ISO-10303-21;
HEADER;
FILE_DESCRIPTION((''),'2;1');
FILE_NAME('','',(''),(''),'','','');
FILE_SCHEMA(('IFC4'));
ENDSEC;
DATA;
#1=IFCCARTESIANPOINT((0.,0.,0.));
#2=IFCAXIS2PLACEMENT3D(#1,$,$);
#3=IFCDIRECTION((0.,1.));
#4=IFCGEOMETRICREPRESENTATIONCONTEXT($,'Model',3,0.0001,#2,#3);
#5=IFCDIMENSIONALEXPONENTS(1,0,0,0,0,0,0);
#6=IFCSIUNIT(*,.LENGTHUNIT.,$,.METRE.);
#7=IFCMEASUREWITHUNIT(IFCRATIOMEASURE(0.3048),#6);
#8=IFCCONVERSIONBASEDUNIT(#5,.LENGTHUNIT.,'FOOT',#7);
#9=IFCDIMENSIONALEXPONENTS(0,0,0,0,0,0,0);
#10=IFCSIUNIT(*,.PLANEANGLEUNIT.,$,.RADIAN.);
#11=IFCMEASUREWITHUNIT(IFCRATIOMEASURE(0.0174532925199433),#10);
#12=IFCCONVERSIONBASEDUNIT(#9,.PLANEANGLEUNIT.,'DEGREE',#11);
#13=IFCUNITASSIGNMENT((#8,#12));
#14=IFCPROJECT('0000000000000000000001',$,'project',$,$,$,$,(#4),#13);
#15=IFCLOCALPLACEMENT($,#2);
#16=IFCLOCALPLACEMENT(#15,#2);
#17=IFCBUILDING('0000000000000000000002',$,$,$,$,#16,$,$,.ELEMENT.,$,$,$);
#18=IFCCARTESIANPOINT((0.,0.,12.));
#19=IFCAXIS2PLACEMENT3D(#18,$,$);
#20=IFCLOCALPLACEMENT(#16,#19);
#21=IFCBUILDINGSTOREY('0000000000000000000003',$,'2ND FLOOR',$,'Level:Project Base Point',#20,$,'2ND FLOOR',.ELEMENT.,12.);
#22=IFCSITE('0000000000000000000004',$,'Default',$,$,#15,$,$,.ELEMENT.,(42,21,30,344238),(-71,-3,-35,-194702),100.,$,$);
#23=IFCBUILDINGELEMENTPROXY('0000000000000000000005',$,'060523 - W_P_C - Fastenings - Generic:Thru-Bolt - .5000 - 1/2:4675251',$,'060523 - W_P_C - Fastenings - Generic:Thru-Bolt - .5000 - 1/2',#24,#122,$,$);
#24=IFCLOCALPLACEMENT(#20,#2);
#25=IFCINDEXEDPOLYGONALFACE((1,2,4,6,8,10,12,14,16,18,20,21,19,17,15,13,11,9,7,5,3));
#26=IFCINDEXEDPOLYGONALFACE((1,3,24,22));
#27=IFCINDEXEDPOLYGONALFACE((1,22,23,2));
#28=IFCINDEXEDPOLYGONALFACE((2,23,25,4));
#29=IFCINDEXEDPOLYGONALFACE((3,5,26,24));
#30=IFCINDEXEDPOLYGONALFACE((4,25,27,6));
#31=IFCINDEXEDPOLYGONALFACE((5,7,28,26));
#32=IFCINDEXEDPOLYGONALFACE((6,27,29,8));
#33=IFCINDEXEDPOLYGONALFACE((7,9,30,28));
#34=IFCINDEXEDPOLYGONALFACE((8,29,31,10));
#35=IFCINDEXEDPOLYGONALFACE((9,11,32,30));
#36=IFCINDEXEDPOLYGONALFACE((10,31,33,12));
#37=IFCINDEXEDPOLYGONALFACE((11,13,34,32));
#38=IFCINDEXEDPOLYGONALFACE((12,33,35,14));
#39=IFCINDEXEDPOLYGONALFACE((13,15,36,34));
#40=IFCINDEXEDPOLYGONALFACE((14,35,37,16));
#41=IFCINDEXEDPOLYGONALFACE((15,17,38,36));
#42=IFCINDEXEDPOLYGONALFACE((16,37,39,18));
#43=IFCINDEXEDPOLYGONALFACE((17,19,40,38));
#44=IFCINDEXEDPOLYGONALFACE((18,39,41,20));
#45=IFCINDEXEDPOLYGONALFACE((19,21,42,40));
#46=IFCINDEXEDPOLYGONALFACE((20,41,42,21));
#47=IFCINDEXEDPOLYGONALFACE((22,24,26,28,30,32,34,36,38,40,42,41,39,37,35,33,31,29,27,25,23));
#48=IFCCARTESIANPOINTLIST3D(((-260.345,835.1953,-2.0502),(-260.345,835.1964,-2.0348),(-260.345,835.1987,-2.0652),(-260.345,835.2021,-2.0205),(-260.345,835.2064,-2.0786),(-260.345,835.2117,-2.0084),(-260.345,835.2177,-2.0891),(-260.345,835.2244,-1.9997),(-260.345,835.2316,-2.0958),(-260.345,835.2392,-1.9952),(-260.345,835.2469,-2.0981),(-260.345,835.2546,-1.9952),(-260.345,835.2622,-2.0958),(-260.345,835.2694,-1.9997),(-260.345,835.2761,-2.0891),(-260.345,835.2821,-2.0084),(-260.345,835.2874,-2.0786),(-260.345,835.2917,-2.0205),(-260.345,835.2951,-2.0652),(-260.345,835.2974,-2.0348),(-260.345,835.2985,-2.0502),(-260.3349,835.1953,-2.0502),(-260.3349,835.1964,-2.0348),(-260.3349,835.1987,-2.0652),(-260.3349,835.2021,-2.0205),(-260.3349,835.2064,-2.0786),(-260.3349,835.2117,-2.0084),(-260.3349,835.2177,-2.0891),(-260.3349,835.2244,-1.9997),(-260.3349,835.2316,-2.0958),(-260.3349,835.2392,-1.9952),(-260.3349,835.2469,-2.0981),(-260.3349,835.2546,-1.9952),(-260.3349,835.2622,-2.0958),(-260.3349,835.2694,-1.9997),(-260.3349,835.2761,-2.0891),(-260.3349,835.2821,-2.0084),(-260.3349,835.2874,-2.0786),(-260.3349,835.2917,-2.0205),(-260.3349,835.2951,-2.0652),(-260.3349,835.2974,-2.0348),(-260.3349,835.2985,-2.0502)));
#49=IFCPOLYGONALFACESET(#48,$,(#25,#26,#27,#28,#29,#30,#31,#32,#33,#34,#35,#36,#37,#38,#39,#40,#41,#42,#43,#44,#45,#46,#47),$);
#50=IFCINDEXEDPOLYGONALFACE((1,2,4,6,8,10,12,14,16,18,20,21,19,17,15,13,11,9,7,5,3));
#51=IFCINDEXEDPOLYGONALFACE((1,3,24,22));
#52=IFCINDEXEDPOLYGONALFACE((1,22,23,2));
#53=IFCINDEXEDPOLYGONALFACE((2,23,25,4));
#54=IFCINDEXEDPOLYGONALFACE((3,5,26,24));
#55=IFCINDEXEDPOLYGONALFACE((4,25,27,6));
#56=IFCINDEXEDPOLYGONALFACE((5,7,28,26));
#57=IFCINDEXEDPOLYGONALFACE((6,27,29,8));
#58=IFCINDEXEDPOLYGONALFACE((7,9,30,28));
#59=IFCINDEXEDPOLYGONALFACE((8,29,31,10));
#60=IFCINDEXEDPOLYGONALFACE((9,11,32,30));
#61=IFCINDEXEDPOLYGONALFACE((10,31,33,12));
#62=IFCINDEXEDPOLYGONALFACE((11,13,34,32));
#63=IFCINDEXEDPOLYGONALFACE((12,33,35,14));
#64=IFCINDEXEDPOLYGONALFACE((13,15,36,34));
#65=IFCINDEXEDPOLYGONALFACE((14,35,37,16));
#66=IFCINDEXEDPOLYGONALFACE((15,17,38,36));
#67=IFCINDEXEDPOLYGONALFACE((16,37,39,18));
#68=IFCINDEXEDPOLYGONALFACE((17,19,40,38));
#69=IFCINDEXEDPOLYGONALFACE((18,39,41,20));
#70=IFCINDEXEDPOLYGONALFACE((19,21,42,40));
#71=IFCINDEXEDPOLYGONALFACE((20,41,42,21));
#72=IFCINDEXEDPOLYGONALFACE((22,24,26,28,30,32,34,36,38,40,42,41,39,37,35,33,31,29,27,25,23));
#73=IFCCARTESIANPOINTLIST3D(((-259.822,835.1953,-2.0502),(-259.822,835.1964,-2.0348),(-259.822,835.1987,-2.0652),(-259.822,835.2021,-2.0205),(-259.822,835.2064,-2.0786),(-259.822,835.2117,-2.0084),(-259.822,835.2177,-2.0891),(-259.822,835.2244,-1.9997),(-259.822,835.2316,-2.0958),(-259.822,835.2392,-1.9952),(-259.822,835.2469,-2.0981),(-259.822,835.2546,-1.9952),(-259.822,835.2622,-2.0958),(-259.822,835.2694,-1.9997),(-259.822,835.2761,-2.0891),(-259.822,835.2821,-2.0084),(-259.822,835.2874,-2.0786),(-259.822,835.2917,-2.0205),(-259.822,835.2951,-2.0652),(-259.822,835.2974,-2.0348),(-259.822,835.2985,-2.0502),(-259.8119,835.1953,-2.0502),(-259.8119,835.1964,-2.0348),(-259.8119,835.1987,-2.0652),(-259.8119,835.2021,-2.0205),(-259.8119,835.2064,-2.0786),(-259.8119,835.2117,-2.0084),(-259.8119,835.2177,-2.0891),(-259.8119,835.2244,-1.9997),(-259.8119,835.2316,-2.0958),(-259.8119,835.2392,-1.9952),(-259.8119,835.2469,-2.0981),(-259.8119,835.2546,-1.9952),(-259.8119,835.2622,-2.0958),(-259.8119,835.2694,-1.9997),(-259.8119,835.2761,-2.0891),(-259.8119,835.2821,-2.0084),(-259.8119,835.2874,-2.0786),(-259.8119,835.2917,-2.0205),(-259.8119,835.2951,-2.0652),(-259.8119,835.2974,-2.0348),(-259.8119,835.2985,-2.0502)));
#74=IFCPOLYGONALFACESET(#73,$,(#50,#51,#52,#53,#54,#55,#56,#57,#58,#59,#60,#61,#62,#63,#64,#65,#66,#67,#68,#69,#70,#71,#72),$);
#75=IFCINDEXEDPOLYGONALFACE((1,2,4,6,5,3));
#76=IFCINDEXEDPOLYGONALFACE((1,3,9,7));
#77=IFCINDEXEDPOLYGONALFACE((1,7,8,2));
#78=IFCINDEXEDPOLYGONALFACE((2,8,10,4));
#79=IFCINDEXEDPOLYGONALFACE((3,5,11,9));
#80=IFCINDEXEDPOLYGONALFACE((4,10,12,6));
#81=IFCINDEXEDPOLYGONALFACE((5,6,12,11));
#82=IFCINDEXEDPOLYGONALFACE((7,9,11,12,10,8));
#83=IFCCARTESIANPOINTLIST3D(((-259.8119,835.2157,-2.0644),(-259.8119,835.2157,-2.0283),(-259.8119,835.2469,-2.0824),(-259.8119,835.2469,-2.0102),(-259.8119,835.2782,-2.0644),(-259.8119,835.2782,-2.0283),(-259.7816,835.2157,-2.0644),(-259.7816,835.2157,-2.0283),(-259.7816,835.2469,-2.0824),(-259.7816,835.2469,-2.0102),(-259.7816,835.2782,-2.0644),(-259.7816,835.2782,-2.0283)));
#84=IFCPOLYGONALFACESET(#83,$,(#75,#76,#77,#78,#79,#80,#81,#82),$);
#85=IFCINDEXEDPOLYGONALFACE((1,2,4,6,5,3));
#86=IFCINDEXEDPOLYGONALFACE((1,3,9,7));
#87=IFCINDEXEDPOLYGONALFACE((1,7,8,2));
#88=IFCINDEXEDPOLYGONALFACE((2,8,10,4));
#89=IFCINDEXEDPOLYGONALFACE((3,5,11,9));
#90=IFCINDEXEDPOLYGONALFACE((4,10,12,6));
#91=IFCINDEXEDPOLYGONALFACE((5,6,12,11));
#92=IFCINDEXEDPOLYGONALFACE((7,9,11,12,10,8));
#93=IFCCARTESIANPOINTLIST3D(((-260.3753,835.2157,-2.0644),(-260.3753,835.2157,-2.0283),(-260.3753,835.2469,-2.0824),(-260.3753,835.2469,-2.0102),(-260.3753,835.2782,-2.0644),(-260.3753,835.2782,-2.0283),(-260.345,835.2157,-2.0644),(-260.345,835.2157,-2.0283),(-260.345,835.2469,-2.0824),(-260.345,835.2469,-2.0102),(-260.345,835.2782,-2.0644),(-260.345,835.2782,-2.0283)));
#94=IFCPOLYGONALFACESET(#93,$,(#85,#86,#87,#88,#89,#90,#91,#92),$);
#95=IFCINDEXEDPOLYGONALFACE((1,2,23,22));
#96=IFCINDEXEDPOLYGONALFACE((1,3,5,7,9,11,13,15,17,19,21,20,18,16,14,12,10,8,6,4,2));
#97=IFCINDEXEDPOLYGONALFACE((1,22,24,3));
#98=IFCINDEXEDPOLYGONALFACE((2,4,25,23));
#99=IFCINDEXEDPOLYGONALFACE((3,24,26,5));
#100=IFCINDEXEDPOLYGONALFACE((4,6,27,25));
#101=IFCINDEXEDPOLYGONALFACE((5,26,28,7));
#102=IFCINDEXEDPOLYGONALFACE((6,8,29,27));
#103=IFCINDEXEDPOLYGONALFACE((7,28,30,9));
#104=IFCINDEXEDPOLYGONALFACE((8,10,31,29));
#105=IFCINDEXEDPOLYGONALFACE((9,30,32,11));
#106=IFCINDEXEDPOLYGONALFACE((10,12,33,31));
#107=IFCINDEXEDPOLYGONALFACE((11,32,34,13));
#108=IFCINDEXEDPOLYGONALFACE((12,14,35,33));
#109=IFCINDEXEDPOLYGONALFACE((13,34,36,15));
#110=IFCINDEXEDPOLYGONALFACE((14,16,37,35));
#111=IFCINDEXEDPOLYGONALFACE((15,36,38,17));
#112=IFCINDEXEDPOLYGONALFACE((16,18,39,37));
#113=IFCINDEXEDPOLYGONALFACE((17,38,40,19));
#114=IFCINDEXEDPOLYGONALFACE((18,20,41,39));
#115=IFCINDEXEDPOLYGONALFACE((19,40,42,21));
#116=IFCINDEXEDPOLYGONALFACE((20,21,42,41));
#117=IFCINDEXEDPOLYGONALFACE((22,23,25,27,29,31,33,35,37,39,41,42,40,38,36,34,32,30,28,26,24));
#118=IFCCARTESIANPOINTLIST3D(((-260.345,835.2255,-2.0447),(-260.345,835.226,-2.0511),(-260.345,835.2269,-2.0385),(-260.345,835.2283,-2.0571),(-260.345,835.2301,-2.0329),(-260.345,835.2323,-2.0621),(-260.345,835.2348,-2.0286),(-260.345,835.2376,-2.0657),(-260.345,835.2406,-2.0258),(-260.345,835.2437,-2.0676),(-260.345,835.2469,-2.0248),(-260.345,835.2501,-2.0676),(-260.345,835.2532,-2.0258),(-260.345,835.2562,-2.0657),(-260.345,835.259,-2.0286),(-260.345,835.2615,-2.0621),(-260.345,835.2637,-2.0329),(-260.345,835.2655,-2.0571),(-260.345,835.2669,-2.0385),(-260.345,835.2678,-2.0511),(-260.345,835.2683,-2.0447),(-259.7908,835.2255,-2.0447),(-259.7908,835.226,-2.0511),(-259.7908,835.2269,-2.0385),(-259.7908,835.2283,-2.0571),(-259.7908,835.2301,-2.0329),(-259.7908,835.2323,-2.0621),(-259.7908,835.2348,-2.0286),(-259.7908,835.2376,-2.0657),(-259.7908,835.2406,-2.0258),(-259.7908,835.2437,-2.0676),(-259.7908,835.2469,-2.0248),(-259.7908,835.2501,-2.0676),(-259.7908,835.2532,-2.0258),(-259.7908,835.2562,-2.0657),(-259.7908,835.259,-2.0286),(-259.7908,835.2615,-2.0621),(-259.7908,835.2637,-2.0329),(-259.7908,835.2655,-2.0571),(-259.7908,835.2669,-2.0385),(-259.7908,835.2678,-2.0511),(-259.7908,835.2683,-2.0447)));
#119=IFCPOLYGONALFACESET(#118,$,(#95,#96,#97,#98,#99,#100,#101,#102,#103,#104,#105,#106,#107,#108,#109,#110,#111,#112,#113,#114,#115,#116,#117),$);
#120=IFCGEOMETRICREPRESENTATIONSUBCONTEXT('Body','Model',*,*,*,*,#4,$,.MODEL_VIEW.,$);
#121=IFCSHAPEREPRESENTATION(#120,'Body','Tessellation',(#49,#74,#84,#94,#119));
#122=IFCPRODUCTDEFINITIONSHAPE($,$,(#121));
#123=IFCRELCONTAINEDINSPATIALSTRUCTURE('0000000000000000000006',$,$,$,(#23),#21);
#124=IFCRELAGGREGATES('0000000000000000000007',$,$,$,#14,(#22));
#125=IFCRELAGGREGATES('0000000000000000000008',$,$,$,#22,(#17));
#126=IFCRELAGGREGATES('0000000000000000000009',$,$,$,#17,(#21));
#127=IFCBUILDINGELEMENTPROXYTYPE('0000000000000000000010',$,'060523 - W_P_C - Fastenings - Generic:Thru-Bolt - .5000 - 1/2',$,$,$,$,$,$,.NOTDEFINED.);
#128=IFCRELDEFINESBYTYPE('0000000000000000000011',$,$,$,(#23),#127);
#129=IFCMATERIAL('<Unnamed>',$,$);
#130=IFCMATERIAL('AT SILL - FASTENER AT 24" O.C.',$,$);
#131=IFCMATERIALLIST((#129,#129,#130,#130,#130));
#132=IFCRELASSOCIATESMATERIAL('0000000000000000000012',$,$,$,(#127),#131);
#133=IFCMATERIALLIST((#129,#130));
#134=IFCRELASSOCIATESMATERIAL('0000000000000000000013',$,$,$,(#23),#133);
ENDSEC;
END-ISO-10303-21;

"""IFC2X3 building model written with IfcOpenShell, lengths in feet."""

from ifc_helpers import new_model, entity, si_unit, converted_unit, direction, frame, frame_2d, origin, place, context, subcontext, project, spatial, polyline, circle, outline, extrude, source, transform, mapped, material, material_list, type_object, type_shapes, element, save


model = new_model("IFC2X3")

# Units and contexts
model_context = context("Model", 3, precision=0.0001, world=origin(), true_north=direction((0.0, 1.0)))
body_context = subcontext(model_context, "Body", "Model", "MODEL_VIEW")
ifc_project = project(units=[converted_unit("LENGTHUNIT", "FOOT", entity("IfcRatioMeasure", 0.3048), si_unit("LENGTHUNIT", "METRE"), dimensions=[1, 0, 0, 0, 0, 0, 0]), converted_unit("PLANEANGLEUNIT", "DEGREE", entity("IfcRatioMeasure", 0.0174532925199433), si_unit("PLANEANGLEUNIT", "RADIAN"), dimensions=[0, 0, 0, 0, 0, 0, 0])], contexts=[model_context])

# Site, building, storey
site_placement = place(None, origin())
site = spatial("IfcSite", under=ifc_project, at=site_placement, Name="Default", CompositionType="ELEMENT", RefLatitude=(42, 21, 30, 344238), RefLongitude=(-71, -3, -35, -194702), RefElevation=100.0)
building_placement = place(site_placement, origin())
building = spatial("IfcBuilding", under=site, at=building_placement, CompositionType="ELEMENT")
storey_placement = place(building_placement, frame((0.0, 0.0, 12.0)))
storey = spatial("IfcBuildingStorey", under=building, at=storey_placement, Name="2ND FLOOR", ObjectType="Level:Project Base Point", LongName="2ND FLOOR", CompositionType="ELEMENT", Elevation=12.0)

# Building element proxy
ifc_material_1 = material(Name="<Unnamed>")
ifc_material_2 = material(Name="AT SILL - FASTENER AT 24\" O.C.")
ifc_material_list_1 = material_list([ifc_material_1, ifc_material_1, ifc_material_2, ifc_material_2, ifc_material_2])
building_element_proxy_type_1 = type_object("IfcBuildingElementProxyType", Name="060523 - W_P_C - Fastenings - Generic:Thru-Bolt - .5000 - 1/2", PredefinedType="NOTDEFINED", material=ifc_material_list_1)
shared_shape_1 = source(origin(), body_context, "Body", "SweptSolid", [
    extrude(circle(Radius=0.0518, at=frame_2d((0.0, 0.0), x_axis=(1.0, 0.0))), frame((0.0, 0.0, 0.0), z_axis=(0.0, 0.0, 1.0), x_axis=(0.0, -1.0, 0.0)), (0.0, 0.0, 1.0), 0.0101),
    extrude(circle(Radius=0.0518, at=frame_2d((0.0, 0.0), x_axis=(1.0, 0.0))), frame((0.0, 0.0, -0.523), z_axis=(0.0, 0.0, 1.0), x_axis=(0.0, -1.0, 0.0)), (0.0, 0.0, 1.0), 0.0101),
    extrude(outline(polyline([(-0.018, -0.0313), (0.018, -0.0313), (0.0361, 0.0), (0.018, 0.0312), (-0.018, 0.0312), (-0.0361, 0.0), (-0.018, -0.0313)])), frame((0.0, 0.0, -0.5533), z_axis=(0.0, 0.0, 1.0), x_axis=(0.866025, -0.5, 0.0)), (0.0, 0.0, 1.0), 0.0303),
    extrude(outline(polyline([(-0.018, -0.0313), (0.018, -0.0313), (0.0361, 0.0), (0.018, 0.0313), (-0.018, 0.0313), (-0.0361, 0.0), (-0.018, -0.0313)])), frame((0.0, 0.0, 0.0101), z_axis=(0.0, 0.0, 1.0), x_axis=(0.0, -1.0, 0.0)), (0.0, 0.0, 1.0), 0.0303),
    extrude(circle(Radius=0.0215, at=frame_2d((0.0, 0.0), x_axis=(1.0, 0.0))), frame((0.0, 0.0, -0.5442), z_axis=(0.0, 0.0, 1.0), x_axis=(0.0, 1.0, 0.0)), (0.0, 0.0, 1.0), 0.5543),
])
type_shapes(building_element_proxy_type_1, [shared_shape_1])
ifc_material_list_2 = material_list([ifc_material_1, ifc_material_2])
proxy_1_placement = place(storey_placement, frame((-260.3349, 835.2469, -2.0463), z_axis=(-1.0, 0.0, 0.0), x_axis=(0.0, -1.0, 0.0)))
element("IfcBuildingElementProxy", 1, at=proxy_1_placement, inside=storey, type_object=building_element_proxy_type_1, material=ifc_material_list_2, Name="060523 - W_P_C - Fastenings - Generic:Thru-Bolt - .5000 - 1/2:4675251", ObjectType="060523 - W_P_C - Fastenings - Generic:Thru-Bolt - .5000 - 1/2", context=body_context, shape_type="MappedRepresentation", body=[
    mapped(shared_shape_1, transform((0.0, 0.0, 0.0), scale=1.0)),
])

save(model, "model.ifc")
